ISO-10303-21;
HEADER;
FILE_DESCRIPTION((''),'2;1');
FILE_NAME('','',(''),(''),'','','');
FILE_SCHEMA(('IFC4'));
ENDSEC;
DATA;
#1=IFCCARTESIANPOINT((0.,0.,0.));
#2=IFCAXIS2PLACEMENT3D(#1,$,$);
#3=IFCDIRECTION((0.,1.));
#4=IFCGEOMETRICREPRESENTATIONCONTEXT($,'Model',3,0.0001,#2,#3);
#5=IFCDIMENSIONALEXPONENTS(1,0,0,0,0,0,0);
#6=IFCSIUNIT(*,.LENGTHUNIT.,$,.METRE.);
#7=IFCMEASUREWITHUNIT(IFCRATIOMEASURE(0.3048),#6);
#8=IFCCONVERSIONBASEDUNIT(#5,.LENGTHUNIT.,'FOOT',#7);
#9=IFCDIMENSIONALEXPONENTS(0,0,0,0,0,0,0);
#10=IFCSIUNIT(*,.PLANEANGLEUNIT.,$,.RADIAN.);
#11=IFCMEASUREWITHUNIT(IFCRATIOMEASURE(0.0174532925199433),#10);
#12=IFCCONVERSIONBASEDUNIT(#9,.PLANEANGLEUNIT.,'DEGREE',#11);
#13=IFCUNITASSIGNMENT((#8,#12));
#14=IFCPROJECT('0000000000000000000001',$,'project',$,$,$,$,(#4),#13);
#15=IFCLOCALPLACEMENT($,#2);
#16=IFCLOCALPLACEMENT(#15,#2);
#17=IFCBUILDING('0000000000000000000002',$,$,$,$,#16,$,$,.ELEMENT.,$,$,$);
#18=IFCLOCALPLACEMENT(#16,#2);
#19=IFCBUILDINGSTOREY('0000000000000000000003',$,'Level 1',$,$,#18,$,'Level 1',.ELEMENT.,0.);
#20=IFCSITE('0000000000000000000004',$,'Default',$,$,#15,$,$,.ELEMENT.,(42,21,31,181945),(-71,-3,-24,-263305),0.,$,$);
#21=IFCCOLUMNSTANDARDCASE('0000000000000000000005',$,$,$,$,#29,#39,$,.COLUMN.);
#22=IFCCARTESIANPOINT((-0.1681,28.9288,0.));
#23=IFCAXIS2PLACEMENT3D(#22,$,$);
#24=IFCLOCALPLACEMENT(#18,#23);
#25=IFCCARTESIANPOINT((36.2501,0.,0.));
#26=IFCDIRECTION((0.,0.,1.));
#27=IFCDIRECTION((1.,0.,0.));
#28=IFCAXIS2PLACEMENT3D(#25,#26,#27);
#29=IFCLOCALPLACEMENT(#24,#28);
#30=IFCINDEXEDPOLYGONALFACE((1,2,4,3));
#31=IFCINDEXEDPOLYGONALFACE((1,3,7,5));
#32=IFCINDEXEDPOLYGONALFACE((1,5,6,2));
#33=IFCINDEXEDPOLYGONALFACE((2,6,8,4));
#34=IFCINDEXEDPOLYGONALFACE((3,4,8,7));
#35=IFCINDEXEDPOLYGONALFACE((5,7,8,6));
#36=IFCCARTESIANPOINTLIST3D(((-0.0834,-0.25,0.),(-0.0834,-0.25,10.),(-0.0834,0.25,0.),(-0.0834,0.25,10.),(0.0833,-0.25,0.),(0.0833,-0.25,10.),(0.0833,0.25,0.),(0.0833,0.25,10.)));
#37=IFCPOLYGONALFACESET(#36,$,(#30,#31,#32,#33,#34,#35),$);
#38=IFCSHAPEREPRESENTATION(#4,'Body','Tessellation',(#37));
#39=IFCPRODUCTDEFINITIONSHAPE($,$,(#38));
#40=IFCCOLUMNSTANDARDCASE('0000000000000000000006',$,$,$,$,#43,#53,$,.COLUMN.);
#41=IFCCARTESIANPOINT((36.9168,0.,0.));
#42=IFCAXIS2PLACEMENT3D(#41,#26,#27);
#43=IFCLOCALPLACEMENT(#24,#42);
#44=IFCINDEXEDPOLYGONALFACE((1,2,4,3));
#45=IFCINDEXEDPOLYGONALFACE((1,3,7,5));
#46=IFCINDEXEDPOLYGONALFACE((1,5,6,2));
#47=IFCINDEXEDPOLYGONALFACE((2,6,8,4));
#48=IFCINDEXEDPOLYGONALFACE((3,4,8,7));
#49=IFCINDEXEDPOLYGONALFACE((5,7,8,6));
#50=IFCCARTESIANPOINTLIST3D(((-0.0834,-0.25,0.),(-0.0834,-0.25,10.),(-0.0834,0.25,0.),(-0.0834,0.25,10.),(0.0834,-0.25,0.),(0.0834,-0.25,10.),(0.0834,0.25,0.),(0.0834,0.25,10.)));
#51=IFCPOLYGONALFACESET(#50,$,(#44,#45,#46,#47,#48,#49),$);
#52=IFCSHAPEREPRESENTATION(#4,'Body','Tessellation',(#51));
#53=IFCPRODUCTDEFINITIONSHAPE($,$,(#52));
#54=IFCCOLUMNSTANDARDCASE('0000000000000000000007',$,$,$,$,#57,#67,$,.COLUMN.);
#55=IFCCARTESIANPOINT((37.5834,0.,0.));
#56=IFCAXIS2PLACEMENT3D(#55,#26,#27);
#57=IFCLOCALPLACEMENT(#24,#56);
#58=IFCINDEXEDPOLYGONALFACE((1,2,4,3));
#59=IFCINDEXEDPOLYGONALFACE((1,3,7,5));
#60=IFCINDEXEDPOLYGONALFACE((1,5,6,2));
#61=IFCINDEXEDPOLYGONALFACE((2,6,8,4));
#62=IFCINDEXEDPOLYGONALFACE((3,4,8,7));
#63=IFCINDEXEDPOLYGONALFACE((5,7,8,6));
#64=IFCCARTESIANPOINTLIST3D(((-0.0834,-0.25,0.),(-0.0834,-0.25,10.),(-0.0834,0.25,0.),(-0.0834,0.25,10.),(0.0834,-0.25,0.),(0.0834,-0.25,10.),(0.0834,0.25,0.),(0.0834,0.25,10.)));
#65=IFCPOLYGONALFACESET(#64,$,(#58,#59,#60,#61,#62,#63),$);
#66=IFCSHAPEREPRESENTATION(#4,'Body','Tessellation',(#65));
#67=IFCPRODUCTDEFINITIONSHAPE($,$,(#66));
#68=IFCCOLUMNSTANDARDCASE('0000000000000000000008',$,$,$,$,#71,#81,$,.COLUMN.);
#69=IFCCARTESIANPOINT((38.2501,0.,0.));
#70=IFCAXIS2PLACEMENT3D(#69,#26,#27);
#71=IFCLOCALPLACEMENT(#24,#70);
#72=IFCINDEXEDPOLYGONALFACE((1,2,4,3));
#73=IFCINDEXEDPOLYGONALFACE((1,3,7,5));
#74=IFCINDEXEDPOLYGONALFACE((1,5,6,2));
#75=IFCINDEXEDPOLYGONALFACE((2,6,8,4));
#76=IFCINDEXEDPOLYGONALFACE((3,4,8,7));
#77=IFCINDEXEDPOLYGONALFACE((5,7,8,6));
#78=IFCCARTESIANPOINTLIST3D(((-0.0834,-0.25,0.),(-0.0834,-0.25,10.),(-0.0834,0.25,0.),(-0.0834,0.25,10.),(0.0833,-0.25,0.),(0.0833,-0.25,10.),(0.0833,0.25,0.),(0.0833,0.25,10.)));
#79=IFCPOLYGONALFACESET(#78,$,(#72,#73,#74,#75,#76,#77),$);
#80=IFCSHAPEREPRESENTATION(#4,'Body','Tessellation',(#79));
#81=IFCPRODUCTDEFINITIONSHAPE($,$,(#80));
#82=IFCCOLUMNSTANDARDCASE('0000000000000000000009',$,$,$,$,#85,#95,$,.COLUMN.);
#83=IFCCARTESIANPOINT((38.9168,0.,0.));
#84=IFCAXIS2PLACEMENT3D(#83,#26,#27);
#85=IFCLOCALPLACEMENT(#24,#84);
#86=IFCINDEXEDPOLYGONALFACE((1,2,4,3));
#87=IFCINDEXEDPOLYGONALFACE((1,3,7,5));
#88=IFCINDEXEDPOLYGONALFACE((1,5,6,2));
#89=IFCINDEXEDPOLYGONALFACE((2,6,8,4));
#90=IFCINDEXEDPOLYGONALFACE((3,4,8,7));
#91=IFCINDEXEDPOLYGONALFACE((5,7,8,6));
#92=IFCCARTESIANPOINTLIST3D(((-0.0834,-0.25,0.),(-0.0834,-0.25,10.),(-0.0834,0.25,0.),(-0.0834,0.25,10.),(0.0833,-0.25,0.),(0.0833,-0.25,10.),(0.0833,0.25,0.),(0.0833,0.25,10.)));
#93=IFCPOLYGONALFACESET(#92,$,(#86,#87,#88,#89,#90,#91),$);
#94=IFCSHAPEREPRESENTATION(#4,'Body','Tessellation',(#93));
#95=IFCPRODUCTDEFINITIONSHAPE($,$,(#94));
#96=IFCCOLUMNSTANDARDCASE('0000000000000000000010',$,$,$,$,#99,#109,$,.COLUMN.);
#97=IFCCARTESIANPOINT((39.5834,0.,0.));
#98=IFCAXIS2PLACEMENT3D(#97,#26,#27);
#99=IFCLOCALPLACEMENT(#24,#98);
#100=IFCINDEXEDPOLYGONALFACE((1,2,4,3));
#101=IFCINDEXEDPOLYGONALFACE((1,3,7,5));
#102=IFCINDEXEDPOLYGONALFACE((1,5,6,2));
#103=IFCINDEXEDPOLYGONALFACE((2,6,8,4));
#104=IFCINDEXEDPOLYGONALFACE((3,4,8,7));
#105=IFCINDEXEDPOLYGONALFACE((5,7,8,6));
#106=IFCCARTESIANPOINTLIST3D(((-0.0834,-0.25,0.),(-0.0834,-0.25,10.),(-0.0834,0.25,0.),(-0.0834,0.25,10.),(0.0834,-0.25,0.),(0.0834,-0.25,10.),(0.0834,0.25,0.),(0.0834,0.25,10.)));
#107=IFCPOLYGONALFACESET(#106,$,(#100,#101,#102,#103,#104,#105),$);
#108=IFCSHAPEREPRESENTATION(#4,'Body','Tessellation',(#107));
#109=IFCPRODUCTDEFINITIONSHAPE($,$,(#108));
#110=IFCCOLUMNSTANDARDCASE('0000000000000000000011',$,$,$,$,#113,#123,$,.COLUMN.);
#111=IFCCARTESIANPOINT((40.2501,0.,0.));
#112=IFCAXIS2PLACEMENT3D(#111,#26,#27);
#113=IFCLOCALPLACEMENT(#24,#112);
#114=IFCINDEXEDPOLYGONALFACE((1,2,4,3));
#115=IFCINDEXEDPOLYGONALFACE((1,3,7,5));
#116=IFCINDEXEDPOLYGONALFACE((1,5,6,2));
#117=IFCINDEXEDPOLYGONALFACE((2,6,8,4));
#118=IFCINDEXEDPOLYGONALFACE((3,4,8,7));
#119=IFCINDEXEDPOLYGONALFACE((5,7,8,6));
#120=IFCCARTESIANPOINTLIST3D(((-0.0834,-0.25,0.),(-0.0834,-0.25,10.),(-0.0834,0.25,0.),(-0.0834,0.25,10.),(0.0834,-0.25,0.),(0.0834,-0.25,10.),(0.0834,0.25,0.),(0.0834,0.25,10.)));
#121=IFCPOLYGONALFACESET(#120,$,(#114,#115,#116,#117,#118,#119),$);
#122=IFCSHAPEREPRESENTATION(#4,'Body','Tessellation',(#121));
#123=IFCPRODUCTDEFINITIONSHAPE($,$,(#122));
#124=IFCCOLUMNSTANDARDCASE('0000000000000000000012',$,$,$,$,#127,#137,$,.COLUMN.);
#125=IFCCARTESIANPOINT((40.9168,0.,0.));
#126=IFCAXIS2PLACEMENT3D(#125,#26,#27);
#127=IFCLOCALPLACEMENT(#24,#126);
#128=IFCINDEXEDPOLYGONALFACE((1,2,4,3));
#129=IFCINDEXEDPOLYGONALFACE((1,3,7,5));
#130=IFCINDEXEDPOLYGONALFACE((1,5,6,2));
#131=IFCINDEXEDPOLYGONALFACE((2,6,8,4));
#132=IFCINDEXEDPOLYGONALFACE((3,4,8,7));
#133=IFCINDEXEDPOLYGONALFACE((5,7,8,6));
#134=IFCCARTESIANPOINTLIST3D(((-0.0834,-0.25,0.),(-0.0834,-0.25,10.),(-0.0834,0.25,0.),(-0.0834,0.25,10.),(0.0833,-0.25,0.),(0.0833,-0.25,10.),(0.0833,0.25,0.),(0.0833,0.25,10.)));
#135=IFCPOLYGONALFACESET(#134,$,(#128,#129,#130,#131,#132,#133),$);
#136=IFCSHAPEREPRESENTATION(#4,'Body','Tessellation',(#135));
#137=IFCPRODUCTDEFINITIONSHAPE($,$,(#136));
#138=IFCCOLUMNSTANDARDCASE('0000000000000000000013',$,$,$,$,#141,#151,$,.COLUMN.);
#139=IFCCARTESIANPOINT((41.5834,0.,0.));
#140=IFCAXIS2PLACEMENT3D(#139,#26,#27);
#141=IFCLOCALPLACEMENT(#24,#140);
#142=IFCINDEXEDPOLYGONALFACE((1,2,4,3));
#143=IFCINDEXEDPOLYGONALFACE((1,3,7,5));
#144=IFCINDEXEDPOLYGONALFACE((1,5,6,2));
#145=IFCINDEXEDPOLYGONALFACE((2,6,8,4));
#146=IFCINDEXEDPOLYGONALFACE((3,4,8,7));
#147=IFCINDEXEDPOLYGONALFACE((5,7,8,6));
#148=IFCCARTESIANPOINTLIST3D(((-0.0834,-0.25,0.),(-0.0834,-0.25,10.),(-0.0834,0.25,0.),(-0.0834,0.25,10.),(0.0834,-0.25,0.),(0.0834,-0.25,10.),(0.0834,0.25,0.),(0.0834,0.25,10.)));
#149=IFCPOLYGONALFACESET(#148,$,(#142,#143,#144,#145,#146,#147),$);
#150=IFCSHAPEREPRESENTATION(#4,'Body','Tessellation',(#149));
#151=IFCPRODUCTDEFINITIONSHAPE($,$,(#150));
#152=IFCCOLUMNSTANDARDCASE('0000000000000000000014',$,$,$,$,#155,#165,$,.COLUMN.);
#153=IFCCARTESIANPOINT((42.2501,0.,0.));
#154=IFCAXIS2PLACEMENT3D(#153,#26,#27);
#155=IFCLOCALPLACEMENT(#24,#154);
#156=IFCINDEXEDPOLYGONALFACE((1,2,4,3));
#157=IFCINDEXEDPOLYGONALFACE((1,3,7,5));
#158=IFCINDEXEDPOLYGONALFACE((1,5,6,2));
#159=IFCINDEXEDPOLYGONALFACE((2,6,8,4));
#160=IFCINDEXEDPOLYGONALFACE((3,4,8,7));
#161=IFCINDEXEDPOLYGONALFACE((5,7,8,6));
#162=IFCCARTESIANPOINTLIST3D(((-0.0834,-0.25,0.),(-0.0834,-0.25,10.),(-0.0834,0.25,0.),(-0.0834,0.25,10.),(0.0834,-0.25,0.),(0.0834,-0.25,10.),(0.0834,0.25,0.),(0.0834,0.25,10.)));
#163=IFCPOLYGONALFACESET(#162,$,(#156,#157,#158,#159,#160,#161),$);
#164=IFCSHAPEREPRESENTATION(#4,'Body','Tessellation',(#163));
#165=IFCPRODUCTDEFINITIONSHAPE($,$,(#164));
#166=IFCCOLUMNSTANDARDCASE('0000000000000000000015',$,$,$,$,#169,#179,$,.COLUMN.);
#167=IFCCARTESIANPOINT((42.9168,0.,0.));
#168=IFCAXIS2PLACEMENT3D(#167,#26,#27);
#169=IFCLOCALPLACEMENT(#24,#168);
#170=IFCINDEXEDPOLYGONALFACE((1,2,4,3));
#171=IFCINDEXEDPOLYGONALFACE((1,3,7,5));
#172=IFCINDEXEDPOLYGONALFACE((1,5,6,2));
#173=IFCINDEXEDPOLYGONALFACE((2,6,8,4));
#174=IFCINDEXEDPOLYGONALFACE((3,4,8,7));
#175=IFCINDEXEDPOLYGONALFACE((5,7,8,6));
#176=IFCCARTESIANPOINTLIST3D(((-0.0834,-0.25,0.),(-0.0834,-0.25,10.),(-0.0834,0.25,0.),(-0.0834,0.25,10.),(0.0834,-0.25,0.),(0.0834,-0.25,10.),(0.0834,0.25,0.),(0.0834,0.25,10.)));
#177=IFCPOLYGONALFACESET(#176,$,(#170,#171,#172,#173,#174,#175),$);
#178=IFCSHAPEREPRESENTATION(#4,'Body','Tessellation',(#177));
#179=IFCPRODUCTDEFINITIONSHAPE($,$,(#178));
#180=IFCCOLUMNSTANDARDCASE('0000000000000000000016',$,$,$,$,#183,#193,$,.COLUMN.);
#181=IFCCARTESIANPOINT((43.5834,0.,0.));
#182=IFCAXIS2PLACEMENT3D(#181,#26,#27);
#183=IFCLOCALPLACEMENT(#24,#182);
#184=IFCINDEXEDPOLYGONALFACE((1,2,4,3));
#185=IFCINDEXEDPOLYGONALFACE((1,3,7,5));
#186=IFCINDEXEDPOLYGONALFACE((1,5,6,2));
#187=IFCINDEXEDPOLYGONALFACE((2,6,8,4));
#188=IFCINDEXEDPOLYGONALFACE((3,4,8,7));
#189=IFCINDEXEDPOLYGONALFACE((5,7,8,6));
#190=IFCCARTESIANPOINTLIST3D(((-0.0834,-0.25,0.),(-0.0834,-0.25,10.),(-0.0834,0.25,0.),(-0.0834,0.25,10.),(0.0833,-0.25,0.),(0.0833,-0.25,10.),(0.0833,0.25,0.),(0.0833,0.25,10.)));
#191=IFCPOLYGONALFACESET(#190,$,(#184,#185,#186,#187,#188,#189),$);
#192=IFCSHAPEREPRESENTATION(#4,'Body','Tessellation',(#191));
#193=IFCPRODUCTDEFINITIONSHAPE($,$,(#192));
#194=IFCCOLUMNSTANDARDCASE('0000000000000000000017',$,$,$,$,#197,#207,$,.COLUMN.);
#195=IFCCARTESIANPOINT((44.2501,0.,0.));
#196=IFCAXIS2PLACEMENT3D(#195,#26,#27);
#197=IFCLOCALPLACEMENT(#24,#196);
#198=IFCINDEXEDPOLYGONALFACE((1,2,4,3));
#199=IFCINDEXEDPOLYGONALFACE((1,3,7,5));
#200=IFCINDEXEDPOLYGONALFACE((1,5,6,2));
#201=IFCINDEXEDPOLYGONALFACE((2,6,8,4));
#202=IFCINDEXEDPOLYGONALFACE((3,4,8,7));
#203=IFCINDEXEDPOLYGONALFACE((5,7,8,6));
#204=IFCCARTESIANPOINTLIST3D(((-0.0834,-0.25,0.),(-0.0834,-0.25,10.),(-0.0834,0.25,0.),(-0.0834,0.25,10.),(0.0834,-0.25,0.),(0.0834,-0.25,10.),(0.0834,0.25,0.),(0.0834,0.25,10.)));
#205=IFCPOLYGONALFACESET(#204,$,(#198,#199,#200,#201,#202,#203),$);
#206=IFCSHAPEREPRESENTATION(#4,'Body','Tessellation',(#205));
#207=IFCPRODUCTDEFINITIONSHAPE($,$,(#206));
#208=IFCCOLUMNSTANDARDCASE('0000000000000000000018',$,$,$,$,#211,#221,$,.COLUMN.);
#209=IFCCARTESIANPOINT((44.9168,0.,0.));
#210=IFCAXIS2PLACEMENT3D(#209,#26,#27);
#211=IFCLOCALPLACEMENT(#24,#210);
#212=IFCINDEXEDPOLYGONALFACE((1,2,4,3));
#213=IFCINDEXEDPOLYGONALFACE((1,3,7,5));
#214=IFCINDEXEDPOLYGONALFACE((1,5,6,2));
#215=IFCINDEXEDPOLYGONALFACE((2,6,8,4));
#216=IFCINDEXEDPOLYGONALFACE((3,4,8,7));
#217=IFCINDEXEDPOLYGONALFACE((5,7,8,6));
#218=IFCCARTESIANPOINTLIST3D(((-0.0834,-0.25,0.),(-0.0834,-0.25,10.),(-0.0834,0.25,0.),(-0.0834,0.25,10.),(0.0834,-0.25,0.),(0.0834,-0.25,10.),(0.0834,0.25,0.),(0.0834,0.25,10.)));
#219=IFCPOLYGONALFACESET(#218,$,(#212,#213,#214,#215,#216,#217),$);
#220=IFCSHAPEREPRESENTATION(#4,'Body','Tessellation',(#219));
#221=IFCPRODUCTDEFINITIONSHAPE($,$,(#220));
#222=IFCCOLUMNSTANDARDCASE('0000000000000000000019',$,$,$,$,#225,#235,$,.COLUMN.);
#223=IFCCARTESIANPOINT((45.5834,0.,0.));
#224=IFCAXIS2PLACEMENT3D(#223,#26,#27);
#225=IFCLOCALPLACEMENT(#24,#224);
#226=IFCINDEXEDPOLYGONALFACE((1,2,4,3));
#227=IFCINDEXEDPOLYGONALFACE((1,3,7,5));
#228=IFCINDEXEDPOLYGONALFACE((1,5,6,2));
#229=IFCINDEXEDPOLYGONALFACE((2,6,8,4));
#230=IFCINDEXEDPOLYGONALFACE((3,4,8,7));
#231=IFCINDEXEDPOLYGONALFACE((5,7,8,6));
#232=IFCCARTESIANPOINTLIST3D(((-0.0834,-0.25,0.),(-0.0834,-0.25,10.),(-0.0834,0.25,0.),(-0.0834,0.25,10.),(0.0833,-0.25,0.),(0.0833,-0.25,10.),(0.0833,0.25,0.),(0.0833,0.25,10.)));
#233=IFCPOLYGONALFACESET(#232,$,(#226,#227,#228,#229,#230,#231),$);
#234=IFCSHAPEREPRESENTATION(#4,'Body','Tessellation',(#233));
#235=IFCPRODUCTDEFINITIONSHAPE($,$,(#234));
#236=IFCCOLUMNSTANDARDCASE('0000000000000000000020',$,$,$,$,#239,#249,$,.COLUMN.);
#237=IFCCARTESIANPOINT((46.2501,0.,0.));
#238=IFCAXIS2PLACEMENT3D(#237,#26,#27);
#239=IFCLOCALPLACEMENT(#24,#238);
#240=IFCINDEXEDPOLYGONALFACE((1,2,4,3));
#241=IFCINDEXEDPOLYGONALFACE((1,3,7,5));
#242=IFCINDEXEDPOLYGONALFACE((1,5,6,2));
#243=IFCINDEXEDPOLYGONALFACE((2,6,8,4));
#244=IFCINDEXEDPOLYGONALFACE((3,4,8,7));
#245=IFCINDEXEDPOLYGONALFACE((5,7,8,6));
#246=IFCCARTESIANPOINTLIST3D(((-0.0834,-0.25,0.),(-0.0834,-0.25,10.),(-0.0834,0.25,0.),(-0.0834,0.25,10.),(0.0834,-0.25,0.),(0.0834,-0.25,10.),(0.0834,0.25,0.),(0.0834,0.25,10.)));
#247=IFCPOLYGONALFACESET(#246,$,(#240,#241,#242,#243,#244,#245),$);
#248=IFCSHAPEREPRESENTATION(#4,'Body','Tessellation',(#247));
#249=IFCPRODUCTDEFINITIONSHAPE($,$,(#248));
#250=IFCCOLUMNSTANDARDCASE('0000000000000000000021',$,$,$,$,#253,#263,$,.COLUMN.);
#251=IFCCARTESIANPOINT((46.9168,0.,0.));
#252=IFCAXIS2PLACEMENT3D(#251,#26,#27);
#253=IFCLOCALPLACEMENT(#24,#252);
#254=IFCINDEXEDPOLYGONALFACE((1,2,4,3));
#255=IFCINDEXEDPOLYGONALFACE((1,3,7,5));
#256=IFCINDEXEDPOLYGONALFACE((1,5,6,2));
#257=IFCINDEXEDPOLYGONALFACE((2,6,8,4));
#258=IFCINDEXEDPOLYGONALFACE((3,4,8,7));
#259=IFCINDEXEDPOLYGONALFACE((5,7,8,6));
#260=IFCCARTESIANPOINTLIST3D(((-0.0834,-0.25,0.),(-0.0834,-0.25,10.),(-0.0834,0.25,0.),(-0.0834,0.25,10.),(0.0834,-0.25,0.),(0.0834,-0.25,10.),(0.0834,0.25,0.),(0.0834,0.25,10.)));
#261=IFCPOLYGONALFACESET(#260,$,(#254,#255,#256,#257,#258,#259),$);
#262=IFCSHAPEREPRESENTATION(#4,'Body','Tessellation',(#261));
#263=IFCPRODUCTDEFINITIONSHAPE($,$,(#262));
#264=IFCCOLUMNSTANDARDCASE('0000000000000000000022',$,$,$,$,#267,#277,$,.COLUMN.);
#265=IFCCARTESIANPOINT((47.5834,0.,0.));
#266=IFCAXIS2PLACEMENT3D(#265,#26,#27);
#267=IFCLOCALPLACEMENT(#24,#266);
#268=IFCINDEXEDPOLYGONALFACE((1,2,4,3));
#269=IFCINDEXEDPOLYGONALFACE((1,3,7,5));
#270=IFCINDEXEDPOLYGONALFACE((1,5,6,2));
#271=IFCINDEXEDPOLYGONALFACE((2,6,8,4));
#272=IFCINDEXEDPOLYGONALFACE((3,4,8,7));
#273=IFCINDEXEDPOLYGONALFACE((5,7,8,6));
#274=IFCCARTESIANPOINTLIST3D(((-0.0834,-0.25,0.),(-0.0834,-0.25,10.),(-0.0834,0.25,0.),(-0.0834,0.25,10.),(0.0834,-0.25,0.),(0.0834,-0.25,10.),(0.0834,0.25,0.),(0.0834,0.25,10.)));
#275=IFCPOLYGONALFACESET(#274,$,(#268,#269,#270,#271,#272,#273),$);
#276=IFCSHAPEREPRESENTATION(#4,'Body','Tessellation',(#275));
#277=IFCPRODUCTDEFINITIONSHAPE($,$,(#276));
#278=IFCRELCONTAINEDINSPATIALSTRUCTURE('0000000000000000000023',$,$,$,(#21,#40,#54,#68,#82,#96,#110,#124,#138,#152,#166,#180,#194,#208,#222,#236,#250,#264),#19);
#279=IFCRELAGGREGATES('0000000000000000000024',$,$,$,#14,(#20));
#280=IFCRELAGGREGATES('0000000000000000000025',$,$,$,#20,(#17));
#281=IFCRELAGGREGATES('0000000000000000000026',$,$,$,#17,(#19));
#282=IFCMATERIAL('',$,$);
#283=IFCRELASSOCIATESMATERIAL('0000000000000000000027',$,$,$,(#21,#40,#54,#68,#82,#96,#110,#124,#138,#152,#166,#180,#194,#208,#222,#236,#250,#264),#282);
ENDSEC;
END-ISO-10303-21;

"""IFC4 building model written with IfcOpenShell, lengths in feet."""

from ifc_helpers import new_model, entity, si_unit, converted_unit, direction, frame, origin, place, context, project, spatial, rectangle, extrude, material, element, save


model = new_model("IFC4")

# Units and contexts
model_context = context("Model", 3, precision=0.0001, world=origin(), true_north=direction((0.0, 1.0)))
ifc_project = project(units=[converted_unit("LENGTHUNIT", "FOOT", entity("IfcRatioMeasure", 0.3048), si_unit("LENGTHUNIT", "METRE"), dimensions=[1, 0, 0, 0, 0, 0, 0]), converted_unit("PLANEANGLEUNIT", "DEGREE", entity("IfcRatioMeasure", 0.0174532925199433), si_unit("PLANEANGLEUNIT", "RADIAN"), dimensions=[0, 0, 0, 0, 0, 0, 0])], contexts=[model_context])

# Site, building, storey
site_placement = place(None, origin())
site = spatial("IfcSite", under=ifc_project, at=site_placement, Name="Default", CompositionType="ELEMENT", RefLatitude=(42, 21, 31, 181945), RefLongitude=(-71, -3, -24, -263305), RefElevation=0.0)
building_placement = place(site_placement, origin())
building = spatial("IfcBuilding", under=site, at=building_placement, CompositionType="ELEMENT")
storey_placement = place(building_placement, origin())
storey = spatial("IfcBuildingStorey", under=building, at=storey_placement, Name="Level 1", LongName="Level 1", CompositionType="ELEMENT", Elevation=0.0)

# Columns
ifc_material_1 = material(Name="")
placement_1 = place(storey_placement, frame((-0.1681, 28.9288, 0.0)))
for number, where, z_axis, x_axis in (
    (1, (36.2501, 0.0, 0.0), (0.0, 0.0, 1.0), (1.0, 0.0, 0.0)),
    (2, (36.9168, 0.0, 0.0), (0.0, 0.0, 1.0), (1.0, 0.0, 0.0)),
    (3, (37.5834, 0.0, 0.0), (0.0, 0.0, 1.0), (1.0, 0.0, 0.0)),
    (4, (38.2501, 0.0, 0.0), (0.0, 0.0, 1.0), (1.0, 0.0, 0.0)),
    (5, (38.9168, 0.0, 0.0), (0.0, 0.0, 1.0), (1.0, 0.0, 0.0)),
    (6, (39.5834, 0.0, 0.0), (0.0, 0.0, 1.0), (1.0, 0.0, 0.0)),
    (7, (40.2501, 0.0, 0.0), (0.0, 0.0, 1.0), (1.0, 0.0, 0.0)),
    (8, (40.9168, 0.0, 0.0), (0.0, 0.0, 1.0), (1.0, 0.0, 0.0)),
    (9, (41.5834, 0.0, 0.0), (0.0, 0.0, 1.0), (1.0, 0.0, 0.0)),
    (10, (42.2501, 0.0, 0.0), (0.0, 0.0, 1.0), (1.0, 0.0, 0.0)),
    (11, (42.9168, 0.0, 0.0), (0.0, 0.0, 1.0), (1.0, 0.0, 0.0)),
    (12, (43.5834, 0.0, 0.0), (0.0, 0.0, 1.0), (1.0, 0.0, 0.0)),
    (13, (44.2501, 0.0, 0.0), (0.0, 0.0, 1.0), (1.0, 0.0, 0.0)),
    (14, (44.9168, 0.0, 0.0), (0.0, 0.0, 1.0), (1.0, 0.0, 0.0)),
    (15, (45.5834, 0.0, 0.0), (0.0, 0.0, 1.0), (1.0, 0.0, 0.0)),
    (16, (46.2501, 0.0, 0.0), (0.0, 0.0, 1.0), (1.0, 0.0, 0.0)),
    (17, (46.9168, 0.0, 0.0), (0.0, 0.0, 1.0), (1.0, 0.0, 0.0)),
    (18, (47.5834, 0.0, 0.0), (0.0, 0.0, 1.0), (1.0, 0.0, 0.0)),
):
    element("IfcColumnStandardCase", number, at=place(placement_1, frame(where, z_axis=z_axis, x_axis=x_axis)), inside=storey, material=ifc_material_1, PredefinedType="COLUMN", context=model_context, shape_type="SweptSolid", body=[
        extrude(rectangle(XDim=0.1667, YDim=0.5), origin(), (0.0, 0.0, 1.0), 10.0),
    ])

save(model, "model.ifc")
